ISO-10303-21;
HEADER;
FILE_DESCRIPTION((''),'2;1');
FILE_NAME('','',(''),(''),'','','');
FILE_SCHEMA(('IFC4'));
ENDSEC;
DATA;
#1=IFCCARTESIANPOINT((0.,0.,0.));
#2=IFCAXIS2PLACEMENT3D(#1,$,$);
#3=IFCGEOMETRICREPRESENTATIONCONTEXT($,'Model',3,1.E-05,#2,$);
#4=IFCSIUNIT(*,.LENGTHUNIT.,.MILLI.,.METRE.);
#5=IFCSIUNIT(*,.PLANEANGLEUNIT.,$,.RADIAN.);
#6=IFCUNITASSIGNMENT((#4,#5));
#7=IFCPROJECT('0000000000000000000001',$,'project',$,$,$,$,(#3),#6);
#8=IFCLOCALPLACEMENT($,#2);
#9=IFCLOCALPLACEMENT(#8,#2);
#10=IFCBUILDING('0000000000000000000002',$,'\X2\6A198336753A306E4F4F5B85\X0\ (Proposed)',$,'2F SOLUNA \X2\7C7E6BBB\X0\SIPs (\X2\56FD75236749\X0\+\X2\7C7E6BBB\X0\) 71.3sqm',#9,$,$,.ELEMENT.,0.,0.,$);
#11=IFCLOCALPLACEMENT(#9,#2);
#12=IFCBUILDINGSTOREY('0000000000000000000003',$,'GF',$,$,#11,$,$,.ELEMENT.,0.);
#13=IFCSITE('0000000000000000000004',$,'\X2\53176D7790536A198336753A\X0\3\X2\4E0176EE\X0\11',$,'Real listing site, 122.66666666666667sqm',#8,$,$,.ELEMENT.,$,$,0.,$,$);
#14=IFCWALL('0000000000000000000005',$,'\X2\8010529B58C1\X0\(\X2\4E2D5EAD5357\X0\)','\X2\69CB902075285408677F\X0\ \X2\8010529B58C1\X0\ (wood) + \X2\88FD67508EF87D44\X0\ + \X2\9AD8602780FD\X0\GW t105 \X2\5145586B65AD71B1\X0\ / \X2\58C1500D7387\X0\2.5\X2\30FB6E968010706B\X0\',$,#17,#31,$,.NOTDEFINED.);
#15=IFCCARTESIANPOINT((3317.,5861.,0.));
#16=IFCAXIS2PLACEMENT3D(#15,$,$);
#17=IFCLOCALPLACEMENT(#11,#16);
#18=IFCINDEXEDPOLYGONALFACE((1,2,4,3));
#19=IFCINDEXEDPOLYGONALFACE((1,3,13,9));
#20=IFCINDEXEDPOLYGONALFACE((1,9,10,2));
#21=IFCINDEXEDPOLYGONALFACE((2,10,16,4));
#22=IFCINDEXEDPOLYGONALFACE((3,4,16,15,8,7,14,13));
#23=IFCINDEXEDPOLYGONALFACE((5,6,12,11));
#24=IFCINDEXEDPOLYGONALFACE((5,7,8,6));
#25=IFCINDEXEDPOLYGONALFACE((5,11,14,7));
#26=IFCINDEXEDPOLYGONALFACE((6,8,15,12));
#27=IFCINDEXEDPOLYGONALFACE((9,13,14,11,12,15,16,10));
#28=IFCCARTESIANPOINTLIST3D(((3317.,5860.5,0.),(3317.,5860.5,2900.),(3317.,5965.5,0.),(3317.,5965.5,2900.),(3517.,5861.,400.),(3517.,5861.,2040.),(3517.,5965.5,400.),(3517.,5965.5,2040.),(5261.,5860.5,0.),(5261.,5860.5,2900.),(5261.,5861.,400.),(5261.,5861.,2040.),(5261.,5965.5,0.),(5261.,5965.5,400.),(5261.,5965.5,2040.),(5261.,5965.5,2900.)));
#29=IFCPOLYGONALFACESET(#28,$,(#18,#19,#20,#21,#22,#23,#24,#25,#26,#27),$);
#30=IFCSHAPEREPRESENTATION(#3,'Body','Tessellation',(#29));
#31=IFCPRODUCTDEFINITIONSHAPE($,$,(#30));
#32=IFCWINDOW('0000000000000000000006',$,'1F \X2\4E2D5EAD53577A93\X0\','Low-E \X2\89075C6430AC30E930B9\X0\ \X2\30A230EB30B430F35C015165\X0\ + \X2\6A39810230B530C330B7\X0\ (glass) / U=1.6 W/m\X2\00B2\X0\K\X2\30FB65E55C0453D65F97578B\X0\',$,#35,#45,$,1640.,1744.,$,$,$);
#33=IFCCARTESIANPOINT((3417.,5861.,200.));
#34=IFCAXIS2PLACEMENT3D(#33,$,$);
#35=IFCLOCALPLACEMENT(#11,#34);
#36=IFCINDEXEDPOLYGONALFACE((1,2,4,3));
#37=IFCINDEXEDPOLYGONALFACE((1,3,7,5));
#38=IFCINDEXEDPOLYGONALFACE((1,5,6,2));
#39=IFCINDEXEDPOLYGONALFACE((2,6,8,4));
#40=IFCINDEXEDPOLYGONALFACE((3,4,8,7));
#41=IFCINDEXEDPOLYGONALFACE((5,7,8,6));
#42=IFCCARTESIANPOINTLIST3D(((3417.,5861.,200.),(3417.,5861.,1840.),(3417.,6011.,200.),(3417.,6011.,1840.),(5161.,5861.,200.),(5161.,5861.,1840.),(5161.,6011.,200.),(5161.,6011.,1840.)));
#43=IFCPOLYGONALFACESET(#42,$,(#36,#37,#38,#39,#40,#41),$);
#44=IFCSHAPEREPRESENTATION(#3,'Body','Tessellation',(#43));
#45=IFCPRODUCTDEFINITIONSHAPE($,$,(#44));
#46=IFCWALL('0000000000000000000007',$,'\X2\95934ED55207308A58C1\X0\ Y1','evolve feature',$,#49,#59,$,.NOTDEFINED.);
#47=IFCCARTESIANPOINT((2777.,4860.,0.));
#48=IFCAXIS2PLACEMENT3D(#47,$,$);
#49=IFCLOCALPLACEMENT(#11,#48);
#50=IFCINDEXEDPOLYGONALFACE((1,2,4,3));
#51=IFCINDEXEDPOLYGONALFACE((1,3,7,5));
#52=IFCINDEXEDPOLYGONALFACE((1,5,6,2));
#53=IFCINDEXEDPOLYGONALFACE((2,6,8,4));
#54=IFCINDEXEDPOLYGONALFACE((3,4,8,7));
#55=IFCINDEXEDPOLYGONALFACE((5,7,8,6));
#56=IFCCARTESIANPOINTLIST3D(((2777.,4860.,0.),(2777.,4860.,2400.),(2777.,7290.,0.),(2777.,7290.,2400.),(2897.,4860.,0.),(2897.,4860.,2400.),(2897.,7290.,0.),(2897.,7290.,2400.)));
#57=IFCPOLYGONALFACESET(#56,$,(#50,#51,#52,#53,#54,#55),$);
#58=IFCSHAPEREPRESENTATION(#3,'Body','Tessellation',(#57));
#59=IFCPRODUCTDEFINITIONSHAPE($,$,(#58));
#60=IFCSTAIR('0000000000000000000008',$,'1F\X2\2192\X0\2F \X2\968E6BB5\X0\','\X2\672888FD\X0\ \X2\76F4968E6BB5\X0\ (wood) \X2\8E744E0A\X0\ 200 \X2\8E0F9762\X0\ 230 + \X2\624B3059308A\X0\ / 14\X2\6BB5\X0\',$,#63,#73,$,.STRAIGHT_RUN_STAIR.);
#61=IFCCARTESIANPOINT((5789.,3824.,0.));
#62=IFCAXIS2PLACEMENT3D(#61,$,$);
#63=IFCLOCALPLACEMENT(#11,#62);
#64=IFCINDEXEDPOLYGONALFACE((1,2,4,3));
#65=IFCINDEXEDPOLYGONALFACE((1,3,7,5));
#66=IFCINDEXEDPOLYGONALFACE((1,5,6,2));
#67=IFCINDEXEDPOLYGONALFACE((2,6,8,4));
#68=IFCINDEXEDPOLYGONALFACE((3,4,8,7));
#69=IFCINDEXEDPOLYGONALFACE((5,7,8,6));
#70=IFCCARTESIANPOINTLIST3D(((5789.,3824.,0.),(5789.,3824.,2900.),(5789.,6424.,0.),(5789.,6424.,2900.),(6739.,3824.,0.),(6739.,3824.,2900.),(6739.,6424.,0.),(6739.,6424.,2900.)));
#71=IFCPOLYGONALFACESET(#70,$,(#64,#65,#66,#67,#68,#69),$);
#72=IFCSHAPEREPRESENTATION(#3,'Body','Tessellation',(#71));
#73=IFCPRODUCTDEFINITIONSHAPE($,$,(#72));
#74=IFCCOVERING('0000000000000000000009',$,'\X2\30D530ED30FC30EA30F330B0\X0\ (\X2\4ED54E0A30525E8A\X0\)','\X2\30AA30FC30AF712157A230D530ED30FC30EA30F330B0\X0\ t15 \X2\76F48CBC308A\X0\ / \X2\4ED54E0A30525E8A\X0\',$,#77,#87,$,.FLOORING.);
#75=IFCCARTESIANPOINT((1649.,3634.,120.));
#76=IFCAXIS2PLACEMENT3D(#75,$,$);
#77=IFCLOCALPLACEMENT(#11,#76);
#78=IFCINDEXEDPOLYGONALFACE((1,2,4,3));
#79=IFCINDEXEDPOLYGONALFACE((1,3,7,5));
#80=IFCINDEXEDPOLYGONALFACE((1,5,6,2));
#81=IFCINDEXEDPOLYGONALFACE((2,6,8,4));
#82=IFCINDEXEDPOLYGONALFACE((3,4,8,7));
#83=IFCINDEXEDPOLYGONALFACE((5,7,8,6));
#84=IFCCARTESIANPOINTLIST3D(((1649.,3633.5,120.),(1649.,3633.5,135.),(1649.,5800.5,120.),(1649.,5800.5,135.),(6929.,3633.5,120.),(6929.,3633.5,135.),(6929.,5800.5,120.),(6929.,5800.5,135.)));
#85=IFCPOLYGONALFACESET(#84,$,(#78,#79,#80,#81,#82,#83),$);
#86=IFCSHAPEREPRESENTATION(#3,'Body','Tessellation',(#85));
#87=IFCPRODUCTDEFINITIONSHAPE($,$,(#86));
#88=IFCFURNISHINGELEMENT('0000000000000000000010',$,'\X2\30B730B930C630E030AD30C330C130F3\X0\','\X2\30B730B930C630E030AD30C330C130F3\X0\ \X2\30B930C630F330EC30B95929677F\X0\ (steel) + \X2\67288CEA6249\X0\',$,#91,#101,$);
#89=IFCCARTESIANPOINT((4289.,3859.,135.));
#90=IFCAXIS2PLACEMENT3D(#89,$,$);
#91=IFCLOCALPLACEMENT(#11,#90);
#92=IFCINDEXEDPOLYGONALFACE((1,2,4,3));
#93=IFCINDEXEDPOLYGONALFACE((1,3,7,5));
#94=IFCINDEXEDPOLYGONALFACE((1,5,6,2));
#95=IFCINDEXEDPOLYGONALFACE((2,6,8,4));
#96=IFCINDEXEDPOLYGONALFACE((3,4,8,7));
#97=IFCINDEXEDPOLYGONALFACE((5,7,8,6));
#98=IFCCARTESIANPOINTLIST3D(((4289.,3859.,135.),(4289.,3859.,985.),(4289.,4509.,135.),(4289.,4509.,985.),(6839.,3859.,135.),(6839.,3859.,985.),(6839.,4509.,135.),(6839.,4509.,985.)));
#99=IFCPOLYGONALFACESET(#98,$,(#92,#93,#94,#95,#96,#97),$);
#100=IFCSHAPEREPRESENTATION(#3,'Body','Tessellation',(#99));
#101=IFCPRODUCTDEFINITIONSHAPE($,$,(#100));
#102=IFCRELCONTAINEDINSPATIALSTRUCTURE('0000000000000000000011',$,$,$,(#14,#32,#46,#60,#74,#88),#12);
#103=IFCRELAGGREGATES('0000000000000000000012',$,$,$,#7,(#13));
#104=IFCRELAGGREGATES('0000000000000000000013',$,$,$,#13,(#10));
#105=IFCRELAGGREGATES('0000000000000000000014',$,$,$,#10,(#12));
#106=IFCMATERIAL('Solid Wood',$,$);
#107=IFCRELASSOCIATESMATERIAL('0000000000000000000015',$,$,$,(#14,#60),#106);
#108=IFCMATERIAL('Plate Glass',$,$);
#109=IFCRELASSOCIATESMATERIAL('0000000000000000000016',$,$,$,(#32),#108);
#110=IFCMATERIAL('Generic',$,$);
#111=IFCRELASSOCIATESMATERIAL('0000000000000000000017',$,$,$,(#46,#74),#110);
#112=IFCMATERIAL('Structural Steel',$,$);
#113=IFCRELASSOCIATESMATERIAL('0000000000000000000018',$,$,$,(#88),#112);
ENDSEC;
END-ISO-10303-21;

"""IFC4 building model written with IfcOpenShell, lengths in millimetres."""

from ifc_helpers import new_model, si_unit, frame, frame_2d, origin, place, context, project, spatial, rectangle, extrude, material, element, fill, save


model = new_model("IFC4")

# Units and contexts
model_context = context("Model", 3, precision=1e-05, world=origin())
ifc_project = project(units=[si_unit("LENGTHUNIT", "METRE", prefix="MILLI"), si_unit("PLANEANGLEUNIT", "RADIAN")], contexts=[model_context])

# Site, building, storey
site_placement = place(None, origin())
site = spatial("IfcSite", under=ifc_project, at=site_placement, Name="北海道標茶町3丁目11", ObjectType="Real listing site, 122.66666666666667sqm", CompositionType="ELEMENT", RefElevation=0.0)
building_placement = place(site_placement, origin())
building = spatial("IfcBuilding", under=site, at=building_placement, Name="標茶町の住宅 (Proposed)", ObjectType="2F SOLUNA 籾殻SIPs (国産杉+籾殻) 71.3sqm", CompositionType="ELEMENT", ElevationOfRefHeight=0.0, ElevationOfTerrain=0.0)
storey_placement = place(building_placement, origin())
storey = spatial("IfcBuildingStorey", under=building, at=storey_placement, Name="GF", CompositionType="ELEMENT", Elevation=0.0)

# Shared definitions
ifc_material_1 = material(Name="Solid Wood")

# Shared definitions
ifc_material_2 = material(Name="Plate Glass")

# Shared definitions
ifc_material_3 = material(Name="Generic")

# Wall, opening, window
wall_1_placement = place(storey_placement, frame((3317.0, 5861.0, 0.0)))
wall_1 = element("IfcWall", 1, at=wall_1_placement, inside=storey, material=ifc_material_1, Name="耐力壁(中庭南)", Description="構造用合板 耐力壁 (wood) + 製材軸組 + 高性能GW t105 充填断熱 / 壁倍率2.5・準耐火", PredefinedType="NOTDEFINED", context=model_context, shape_type="SweptSolid", body=[
    extrude(rectangle(XDim=1944.0, YDim=105.0, at=frame_2d((972.0, 52.0))), frame((3317.0, 5861.0, 0.0)), (0.0, 0.0, 1.0), 2900.0),
])
opening_1_placement = place(storey_placement, frame((3417.0, 5861.0, 200.0)))
opening_1 = element("IfcOpeningElement", 2, at=opening_1_placement, cuts=wall_1, PredefinedType="NOTDEFINED", context=model_context, shape_type="SweptSolid", body=[
    extrude(rectangle(XDim=1744.0, YDim=150.0, at=frame_2d((872.0, 75.0))), frame((3417.0, 5861.0, 200.0)), (0.0, 0.0, 1.0), 1640.0),
])
window_1_placement = place(storey_placement, frame((3417.0, 5861.0, 200.0)))
window_1 = element("IfcWindow", 3, at=window_1_placement, inside=storey, material=ifc_material_2, Name="1F 中庭南窓", Description="Low-E 複層ガラス アルゴン封入 + 樹脂サッシ (glass) / U=1.6 W/m²K・日射取得型", OverallHeight=1640.0, OverallWidth=1744.0, context=model_context, shape_type="SweptSolid", body=[
    extrude(rectangle(XDim=1744.0, YDim=150.0, at=frame_2d((872.0, 75.0))), frame((3417.0, 5861.0, 200.0)), (0.0, 0.0, 1.0), 1640.0),
])
fill(opening_1, window_1)

# Wall
wall_2_placement = place(storey_placement, frame((2777.0, 4860.0, 0.0)))
element("IfcWall", 4, at=wall_2_placement, inside=storey, material=ifc_material_3, Name="間仕切り壁 Y1", Description="evolve feature", PredefinedType="NOTDEFINED", context=model_context, shape_type="SweptSolid", body=[
    extrude(rectangle(XDim=120.0, YDim=2430.0, at=frame_2d((60.0, 1215.0))), frame((2777.0, 4860.0, 0.0)), (0.0, 0.0, 1.0), 2400.0),
])

# Stair
stair_placement = place(storey_placement, frame((5789.0, 3824.0, 0.0)))
element("IfcStair", 5, at=stair_placement, inside=storey, material=ifc_material_1, Name="1F→2F 階段", Description="木製 直階段 (wood) 蹴上 200 踏面 230 + 手すり / 14段", PredefinedType="STRAIGHT_RUN_STAIR", context=model_context, shape_type="SweptSolid", body=[
    extrude(rectangle(XDim=950.0, YDim=2600.0, at=frame_2d((475.0, 1300.0))), frame((5789.0, 3824.0, 0.0)), (0.0, 0.0, 1.0), 2900.0),
])

# Covering
covering_placement = place(storey_placement, frame((1649.0, 3634.0, 120.0)))
element("IfcCovering", 6, at=covering_placement, inside=storey, material=ifc_material_3, Name="フローリング (仕上げ床)", Description="オーク無垢フローリング t15 直貼り / 仕上げ床", PredefinedType="FLOORING", context=model_context, shape_type="SweptSolid", body=[
    extrude(rectangle(XDim=5280.0, YDim=2167.0, at=frame_2d((2640.0, 1083.0))), frame((1649.0, 3634.0, 120.0)), (0.0, 0.0, 1.0), 15.0),
])

# Furnishing element
ifc_material_4 = material(Name="Structural Steel")
furnishing_placement = place(storey_placement, frame((4289.0, 3859.0, 135.0)))
element("IfcFurnishingElement", 7, at=furnishing_placement, inside=storey, material=ifc_material_4, Name="システムキッチン", Description="システムキッチン ステンレス天板 (steel) + 木質扉", context=model_context, shape_type="SweptSolid", body=[
    extrude(rectangle(XDim=2550.0, YDim=650.0, at=frame_2d((1275.0, 325.0))), frame((4289.0, 3859.0, 135.0)), (0.0, 0.0, 1.0), 850.0),
])

save(model, "model.ifc")
